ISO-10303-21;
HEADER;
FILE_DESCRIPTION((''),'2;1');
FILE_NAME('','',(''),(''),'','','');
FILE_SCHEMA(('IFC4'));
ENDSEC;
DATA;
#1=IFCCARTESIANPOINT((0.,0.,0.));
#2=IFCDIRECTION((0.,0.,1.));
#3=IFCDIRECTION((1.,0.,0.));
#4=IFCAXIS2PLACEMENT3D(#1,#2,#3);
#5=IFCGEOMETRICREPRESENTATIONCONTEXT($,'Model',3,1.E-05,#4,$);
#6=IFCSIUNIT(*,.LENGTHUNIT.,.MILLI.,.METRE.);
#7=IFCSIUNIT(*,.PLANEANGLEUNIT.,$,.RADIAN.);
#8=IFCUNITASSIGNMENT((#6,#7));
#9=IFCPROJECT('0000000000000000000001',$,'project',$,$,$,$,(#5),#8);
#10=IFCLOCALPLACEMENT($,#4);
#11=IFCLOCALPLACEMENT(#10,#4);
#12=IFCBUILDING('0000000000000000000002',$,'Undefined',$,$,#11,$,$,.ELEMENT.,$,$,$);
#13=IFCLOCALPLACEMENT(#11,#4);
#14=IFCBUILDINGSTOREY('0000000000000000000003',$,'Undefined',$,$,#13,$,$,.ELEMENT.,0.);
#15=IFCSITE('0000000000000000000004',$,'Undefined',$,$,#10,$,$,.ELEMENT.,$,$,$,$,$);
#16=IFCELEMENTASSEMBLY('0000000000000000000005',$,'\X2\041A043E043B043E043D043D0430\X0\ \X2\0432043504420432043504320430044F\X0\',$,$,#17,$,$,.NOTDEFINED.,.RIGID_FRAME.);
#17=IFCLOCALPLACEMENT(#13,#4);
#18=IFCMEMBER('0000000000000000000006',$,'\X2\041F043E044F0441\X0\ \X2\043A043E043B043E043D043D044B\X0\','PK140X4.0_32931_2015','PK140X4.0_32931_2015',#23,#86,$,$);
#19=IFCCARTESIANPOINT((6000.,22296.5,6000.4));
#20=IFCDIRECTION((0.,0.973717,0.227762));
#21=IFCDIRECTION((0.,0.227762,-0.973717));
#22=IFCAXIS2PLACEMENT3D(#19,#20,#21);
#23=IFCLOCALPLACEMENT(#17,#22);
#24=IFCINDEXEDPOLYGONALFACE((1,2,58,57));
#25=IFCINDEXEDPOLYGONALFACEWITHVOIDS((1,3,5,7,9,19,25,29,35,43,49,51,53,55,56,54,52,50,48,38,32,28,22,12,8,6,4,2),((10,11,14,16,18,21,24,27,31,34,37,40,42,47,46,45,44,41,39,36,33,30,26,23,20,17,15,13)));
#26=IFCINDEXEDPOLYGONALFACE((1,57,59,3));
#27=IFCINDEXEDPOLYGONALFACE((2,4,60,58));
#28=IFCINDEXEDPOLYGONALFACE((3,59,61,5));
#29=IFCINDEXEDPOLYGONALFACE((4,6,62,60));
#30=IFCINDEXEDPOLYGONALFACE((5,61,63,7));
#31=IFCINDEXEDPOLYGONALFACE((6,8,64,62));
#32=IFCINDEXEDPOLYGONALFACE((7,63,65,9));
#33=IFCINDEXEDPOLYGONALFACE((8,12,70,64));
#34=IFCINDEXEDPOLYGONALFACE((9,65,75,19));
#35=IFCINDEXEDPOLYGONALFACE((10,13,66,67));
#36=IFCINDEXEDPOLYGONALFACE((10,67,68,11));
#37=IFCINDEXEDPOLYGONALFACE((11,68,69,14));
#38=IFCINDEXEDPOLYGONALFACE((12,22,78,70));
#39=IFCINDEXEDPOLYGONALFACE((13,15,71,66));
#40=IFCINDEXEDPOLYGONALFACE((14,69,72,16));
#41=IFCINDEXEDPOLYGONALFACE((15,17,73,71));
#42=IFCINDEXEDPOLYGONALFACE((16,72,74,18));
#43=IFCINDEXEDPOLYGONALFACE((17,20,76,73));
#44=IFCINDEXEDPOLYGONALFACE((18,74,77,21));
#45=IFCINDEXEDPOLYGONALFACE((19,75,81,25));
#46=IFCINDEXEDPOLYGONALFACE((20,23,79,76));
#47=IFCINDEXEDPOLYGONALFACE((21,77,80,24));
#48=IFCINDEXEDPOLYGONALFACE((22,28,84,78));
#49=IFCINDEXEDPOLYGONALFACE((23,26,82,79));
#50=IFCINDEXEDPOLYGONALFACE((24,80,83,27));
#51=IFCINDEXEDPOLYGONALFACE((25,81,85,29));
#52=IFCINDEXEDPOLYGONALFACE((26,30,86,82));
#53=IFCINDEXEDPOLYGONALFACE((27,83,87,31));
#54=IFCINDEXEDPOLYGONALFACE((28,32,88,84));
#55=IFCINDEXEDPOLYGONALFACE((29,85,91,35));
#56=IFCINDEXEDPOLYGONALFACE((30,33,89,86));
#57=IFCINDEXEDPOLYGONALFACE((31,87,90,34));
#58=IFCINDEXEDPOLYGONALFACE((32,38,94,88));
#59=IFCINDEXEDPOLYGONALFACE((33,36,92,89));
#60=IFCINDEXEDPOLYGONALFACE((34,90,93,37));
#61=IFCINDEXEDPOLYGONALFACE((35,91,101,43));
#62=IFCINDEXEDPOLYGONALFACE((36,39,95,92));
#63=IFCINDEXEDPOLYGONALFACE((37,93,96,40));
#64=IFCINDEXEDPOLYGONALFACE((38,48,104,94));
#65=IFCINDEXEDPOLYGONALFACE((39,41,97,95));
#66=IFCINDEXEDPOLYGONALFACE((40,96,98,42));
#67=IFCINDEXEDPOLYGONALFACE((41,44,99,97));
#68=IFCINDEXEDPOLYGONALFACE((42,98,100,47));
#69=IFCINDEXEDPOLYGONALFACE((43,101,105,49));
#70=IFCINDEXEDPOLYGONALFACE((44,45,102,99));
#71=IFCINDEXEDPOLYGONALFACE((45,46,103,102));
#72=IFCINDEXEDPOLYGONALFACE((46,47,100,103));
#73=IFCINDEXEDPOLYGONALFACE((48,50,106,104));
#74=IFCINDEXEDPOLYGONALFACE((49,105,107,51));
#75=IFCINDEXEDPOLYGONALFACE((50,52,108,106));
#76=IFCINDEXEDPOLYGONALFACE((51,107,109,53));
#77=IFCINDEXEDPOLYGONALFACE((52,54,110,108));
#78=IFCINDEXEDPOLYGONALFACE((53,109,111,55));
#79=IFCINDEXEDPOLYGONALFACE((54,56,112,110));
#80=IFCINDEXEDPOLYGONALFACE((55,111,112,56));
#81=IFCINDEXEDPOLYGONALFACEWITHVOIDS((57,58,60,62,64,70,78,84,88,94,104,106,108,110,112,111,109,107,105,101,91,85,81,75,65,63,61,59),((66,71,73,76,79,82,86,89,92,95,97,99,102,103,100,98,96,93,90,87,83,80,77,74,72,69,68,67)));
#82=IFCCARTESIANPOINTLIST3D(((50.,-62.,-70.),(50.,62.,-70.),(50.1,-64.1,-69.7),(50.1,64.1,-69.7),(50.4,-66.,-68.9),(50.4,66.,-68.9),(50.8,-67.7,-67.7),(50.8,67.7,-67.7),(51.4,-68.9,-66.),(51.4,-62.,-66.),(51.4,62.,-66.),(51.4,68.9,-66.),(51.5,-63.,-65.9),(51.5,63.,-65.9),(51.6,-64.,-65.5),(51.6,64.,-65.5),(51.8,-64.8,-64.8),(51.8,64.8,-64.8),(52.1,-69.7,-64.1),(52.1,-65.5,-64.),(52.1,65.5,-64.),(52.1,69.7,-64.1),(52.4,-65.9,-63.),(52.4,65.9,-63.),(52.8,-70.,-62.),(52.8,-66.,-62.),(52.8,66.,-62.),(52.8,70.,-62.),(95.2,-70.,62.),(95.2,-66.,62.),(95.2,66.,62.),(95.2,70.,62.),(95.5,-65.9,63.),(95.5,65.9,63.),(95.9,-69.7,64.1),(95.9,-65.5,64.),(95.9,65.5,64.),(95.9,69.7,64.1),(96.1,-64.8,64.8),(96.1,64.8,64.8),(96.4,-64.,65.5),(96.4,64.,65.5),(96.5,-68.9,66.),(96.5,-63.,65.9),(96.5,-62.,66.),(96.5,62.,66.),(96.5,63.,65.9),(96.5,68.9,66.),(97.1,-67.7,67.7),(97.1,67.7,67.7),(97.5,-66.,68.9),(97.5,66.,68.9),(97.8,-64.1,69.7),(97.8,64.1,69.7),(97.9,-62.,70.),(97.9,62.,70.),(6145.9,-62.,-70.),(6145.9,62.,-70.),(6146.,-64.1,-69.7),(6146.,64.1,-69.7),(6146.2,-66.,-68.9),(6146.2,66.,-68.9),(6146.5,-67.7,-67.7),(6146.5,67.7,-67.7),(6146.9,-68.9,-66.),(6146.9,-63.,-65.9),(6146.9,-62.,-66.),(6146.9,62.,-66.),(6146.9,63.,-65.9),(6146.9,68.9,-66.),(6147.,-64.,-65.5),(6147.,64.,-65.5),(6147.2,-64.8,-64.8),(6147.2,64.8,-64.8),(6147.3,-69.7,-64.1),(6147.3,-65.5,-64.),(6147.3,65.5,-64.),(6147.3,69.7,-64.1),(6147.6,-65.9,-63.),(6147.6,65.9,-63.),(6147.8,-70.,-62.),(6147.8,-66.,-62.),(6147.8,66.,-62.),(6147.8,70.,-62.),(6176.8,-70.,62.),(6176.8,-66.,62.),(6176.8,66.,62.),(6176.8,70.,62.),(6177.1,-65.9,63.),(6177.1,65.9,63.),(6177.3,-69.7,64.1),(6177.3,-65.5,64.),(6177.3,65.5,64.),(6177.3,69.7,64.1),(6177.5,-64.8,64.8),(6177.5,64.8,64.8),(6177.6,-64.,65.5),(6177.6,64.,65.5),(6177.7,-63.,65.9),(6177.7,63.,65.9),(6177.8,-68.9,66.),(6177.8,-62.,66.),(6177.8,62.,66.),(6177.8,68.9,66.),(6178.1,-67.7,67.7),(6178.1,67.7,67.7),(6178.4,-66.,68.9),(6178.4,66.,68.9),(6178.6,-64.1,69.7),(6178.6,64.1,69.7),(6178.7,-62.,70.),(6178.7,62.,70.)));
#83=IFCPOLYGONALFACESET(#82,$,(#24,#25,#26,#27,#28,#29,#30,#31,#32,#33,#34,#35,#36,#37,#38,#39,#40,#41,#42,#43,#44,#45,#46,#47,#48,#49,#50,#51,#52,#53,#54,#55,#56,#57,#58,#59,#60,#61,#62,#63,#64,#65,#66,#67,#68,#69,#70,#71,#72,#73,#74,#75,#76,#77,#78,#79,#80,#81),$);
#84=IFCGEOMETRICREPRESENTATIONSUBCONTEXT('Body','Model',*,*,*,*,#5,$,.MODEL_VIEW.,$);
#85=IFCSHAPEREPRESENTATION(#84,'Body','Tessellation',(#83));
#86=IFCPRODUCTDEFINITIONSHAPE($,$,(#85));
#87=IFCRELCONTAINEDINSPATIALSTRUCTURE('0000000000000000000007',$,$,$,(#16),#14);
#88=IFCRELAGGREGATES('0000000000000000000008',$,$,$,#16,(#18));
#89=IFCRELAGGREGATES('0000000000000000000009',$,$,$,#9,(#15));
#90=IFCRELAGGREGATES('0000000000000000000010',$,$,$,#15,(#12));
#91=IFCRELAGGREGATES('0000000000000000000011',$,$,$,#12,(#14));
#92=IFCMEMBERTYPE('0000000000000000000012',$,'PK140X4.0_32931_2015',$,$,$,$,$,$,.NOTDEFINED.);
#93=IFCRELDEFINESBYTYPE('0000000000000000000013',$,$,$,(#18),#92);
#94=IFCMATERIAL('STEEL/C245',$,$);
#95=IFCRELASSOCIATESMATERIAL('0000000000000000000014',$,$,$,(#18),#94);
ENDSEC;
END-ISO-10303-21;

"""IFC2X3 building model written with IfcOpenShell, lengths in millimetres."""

from ifc_helpers import new_model, si_unit, frame, origin_with_axes, origin_2d_with_axis, place, context, subcontext, project, spatial, hollow_rectangle, extrude, clip, halfspace, material, type_object, element, aggregate, save


model = new_model("IFC2X3")

# Units and contexts
model_context = context("Model", 3, precision=1e-05, world=origin_with_axes())
body_context = subcontext(model_context, "Body", "Model", "MODEL_VIEW")
ifc_project = project(units=[si_unit("LENGTHUNIT", "METRE", prefix="MILLI"), si_unit("PLANEANGLEUNIT", "RADIAN")], contexts=[model_context])

# Site, building, storey
site_placement = place(None, origin_with_axes())
site = spatial("IfcSite", under=ifc_project, at=site_placement, Name="Undefined", CompositionType="ELEMENT")
building_placement = place(site_placement, origin_with_axes())
building = spatial("IfcBuilding", under=site, at=building_placement, Name="Undefined", CompositionType="ELEMENT")
storey_placement = place(building_placement, origin_with_axes())
storey = spatial("IfcBuildingStorey", under=building, at=storey_placement, Name="Undefined", CompositionType="ELEMENT", Elevation=0.0)

# Shared definitions
ifc_material_1 = material(Name="STEEL/C245")

# Element assembly
assembly_1_placement = place(storey_placement, origin_with_axes())
assembly_1 = element("IfcElementAssembly", 1, at=assembly_1_placement, inside=storey, Name="Колонна ветвевая", AssemblyPlace="NOTDEFINED", PredefinedType="RIGID_FRAME")

# Shared definitions
member_type_1 = type_object("IfcMemberType", Name="PK140X4.0_32931_2015", PredefinedType="NOTDEFINED")

# Member
member_1_placement = place(assembly_1_placement, frame((6000.0, 22296.5, 6000.4), z_axis=(0.0, 0.973717, 0.227762), x_axis=(0.0, 0.227762, -0.973717)))
member_1 = element("IfcMember", 2, at=member_1_placement, type_object=member_type_1, material=ifc_material_1, Name="Пояс колонны", Description="PK140X4.0_32931_2015", ObjectType="PK140X4.0_32931_2015", context=body_context, shape_type="Clipping", body=[
    clip(clip(extrude(hollow_rectangle(XDim=140.0, YDim=140.0, WallThickness=4.0, InnerFilletRadius=4.0, OuterFilletRadius=8.0, at=origin_2d_with_axis()), frame((6203.0, 0.0, 0.0), z_axis=(-1.0, 0.0, 0.0), x_axis=(0.0, -1.0, 0.0)), (0.0, 0.0, 1.0), 6169.8), halfspace(frame((6128.6, 0.0, -144.2), z_axis=(0.973717, 0.0, -0.227762), x_axis=(-0.227762, 0.0, -0.973717)), False)), halfspace(frame((33.3, 0.0, -119.0), z_axis=(-0.946221, 0.0, 0.32352), x_axis=(0.32352, 0.0, 0.946221)), False)),
])

aggregate(assembly_1, [member_1])

save(model, "model.ifc")
